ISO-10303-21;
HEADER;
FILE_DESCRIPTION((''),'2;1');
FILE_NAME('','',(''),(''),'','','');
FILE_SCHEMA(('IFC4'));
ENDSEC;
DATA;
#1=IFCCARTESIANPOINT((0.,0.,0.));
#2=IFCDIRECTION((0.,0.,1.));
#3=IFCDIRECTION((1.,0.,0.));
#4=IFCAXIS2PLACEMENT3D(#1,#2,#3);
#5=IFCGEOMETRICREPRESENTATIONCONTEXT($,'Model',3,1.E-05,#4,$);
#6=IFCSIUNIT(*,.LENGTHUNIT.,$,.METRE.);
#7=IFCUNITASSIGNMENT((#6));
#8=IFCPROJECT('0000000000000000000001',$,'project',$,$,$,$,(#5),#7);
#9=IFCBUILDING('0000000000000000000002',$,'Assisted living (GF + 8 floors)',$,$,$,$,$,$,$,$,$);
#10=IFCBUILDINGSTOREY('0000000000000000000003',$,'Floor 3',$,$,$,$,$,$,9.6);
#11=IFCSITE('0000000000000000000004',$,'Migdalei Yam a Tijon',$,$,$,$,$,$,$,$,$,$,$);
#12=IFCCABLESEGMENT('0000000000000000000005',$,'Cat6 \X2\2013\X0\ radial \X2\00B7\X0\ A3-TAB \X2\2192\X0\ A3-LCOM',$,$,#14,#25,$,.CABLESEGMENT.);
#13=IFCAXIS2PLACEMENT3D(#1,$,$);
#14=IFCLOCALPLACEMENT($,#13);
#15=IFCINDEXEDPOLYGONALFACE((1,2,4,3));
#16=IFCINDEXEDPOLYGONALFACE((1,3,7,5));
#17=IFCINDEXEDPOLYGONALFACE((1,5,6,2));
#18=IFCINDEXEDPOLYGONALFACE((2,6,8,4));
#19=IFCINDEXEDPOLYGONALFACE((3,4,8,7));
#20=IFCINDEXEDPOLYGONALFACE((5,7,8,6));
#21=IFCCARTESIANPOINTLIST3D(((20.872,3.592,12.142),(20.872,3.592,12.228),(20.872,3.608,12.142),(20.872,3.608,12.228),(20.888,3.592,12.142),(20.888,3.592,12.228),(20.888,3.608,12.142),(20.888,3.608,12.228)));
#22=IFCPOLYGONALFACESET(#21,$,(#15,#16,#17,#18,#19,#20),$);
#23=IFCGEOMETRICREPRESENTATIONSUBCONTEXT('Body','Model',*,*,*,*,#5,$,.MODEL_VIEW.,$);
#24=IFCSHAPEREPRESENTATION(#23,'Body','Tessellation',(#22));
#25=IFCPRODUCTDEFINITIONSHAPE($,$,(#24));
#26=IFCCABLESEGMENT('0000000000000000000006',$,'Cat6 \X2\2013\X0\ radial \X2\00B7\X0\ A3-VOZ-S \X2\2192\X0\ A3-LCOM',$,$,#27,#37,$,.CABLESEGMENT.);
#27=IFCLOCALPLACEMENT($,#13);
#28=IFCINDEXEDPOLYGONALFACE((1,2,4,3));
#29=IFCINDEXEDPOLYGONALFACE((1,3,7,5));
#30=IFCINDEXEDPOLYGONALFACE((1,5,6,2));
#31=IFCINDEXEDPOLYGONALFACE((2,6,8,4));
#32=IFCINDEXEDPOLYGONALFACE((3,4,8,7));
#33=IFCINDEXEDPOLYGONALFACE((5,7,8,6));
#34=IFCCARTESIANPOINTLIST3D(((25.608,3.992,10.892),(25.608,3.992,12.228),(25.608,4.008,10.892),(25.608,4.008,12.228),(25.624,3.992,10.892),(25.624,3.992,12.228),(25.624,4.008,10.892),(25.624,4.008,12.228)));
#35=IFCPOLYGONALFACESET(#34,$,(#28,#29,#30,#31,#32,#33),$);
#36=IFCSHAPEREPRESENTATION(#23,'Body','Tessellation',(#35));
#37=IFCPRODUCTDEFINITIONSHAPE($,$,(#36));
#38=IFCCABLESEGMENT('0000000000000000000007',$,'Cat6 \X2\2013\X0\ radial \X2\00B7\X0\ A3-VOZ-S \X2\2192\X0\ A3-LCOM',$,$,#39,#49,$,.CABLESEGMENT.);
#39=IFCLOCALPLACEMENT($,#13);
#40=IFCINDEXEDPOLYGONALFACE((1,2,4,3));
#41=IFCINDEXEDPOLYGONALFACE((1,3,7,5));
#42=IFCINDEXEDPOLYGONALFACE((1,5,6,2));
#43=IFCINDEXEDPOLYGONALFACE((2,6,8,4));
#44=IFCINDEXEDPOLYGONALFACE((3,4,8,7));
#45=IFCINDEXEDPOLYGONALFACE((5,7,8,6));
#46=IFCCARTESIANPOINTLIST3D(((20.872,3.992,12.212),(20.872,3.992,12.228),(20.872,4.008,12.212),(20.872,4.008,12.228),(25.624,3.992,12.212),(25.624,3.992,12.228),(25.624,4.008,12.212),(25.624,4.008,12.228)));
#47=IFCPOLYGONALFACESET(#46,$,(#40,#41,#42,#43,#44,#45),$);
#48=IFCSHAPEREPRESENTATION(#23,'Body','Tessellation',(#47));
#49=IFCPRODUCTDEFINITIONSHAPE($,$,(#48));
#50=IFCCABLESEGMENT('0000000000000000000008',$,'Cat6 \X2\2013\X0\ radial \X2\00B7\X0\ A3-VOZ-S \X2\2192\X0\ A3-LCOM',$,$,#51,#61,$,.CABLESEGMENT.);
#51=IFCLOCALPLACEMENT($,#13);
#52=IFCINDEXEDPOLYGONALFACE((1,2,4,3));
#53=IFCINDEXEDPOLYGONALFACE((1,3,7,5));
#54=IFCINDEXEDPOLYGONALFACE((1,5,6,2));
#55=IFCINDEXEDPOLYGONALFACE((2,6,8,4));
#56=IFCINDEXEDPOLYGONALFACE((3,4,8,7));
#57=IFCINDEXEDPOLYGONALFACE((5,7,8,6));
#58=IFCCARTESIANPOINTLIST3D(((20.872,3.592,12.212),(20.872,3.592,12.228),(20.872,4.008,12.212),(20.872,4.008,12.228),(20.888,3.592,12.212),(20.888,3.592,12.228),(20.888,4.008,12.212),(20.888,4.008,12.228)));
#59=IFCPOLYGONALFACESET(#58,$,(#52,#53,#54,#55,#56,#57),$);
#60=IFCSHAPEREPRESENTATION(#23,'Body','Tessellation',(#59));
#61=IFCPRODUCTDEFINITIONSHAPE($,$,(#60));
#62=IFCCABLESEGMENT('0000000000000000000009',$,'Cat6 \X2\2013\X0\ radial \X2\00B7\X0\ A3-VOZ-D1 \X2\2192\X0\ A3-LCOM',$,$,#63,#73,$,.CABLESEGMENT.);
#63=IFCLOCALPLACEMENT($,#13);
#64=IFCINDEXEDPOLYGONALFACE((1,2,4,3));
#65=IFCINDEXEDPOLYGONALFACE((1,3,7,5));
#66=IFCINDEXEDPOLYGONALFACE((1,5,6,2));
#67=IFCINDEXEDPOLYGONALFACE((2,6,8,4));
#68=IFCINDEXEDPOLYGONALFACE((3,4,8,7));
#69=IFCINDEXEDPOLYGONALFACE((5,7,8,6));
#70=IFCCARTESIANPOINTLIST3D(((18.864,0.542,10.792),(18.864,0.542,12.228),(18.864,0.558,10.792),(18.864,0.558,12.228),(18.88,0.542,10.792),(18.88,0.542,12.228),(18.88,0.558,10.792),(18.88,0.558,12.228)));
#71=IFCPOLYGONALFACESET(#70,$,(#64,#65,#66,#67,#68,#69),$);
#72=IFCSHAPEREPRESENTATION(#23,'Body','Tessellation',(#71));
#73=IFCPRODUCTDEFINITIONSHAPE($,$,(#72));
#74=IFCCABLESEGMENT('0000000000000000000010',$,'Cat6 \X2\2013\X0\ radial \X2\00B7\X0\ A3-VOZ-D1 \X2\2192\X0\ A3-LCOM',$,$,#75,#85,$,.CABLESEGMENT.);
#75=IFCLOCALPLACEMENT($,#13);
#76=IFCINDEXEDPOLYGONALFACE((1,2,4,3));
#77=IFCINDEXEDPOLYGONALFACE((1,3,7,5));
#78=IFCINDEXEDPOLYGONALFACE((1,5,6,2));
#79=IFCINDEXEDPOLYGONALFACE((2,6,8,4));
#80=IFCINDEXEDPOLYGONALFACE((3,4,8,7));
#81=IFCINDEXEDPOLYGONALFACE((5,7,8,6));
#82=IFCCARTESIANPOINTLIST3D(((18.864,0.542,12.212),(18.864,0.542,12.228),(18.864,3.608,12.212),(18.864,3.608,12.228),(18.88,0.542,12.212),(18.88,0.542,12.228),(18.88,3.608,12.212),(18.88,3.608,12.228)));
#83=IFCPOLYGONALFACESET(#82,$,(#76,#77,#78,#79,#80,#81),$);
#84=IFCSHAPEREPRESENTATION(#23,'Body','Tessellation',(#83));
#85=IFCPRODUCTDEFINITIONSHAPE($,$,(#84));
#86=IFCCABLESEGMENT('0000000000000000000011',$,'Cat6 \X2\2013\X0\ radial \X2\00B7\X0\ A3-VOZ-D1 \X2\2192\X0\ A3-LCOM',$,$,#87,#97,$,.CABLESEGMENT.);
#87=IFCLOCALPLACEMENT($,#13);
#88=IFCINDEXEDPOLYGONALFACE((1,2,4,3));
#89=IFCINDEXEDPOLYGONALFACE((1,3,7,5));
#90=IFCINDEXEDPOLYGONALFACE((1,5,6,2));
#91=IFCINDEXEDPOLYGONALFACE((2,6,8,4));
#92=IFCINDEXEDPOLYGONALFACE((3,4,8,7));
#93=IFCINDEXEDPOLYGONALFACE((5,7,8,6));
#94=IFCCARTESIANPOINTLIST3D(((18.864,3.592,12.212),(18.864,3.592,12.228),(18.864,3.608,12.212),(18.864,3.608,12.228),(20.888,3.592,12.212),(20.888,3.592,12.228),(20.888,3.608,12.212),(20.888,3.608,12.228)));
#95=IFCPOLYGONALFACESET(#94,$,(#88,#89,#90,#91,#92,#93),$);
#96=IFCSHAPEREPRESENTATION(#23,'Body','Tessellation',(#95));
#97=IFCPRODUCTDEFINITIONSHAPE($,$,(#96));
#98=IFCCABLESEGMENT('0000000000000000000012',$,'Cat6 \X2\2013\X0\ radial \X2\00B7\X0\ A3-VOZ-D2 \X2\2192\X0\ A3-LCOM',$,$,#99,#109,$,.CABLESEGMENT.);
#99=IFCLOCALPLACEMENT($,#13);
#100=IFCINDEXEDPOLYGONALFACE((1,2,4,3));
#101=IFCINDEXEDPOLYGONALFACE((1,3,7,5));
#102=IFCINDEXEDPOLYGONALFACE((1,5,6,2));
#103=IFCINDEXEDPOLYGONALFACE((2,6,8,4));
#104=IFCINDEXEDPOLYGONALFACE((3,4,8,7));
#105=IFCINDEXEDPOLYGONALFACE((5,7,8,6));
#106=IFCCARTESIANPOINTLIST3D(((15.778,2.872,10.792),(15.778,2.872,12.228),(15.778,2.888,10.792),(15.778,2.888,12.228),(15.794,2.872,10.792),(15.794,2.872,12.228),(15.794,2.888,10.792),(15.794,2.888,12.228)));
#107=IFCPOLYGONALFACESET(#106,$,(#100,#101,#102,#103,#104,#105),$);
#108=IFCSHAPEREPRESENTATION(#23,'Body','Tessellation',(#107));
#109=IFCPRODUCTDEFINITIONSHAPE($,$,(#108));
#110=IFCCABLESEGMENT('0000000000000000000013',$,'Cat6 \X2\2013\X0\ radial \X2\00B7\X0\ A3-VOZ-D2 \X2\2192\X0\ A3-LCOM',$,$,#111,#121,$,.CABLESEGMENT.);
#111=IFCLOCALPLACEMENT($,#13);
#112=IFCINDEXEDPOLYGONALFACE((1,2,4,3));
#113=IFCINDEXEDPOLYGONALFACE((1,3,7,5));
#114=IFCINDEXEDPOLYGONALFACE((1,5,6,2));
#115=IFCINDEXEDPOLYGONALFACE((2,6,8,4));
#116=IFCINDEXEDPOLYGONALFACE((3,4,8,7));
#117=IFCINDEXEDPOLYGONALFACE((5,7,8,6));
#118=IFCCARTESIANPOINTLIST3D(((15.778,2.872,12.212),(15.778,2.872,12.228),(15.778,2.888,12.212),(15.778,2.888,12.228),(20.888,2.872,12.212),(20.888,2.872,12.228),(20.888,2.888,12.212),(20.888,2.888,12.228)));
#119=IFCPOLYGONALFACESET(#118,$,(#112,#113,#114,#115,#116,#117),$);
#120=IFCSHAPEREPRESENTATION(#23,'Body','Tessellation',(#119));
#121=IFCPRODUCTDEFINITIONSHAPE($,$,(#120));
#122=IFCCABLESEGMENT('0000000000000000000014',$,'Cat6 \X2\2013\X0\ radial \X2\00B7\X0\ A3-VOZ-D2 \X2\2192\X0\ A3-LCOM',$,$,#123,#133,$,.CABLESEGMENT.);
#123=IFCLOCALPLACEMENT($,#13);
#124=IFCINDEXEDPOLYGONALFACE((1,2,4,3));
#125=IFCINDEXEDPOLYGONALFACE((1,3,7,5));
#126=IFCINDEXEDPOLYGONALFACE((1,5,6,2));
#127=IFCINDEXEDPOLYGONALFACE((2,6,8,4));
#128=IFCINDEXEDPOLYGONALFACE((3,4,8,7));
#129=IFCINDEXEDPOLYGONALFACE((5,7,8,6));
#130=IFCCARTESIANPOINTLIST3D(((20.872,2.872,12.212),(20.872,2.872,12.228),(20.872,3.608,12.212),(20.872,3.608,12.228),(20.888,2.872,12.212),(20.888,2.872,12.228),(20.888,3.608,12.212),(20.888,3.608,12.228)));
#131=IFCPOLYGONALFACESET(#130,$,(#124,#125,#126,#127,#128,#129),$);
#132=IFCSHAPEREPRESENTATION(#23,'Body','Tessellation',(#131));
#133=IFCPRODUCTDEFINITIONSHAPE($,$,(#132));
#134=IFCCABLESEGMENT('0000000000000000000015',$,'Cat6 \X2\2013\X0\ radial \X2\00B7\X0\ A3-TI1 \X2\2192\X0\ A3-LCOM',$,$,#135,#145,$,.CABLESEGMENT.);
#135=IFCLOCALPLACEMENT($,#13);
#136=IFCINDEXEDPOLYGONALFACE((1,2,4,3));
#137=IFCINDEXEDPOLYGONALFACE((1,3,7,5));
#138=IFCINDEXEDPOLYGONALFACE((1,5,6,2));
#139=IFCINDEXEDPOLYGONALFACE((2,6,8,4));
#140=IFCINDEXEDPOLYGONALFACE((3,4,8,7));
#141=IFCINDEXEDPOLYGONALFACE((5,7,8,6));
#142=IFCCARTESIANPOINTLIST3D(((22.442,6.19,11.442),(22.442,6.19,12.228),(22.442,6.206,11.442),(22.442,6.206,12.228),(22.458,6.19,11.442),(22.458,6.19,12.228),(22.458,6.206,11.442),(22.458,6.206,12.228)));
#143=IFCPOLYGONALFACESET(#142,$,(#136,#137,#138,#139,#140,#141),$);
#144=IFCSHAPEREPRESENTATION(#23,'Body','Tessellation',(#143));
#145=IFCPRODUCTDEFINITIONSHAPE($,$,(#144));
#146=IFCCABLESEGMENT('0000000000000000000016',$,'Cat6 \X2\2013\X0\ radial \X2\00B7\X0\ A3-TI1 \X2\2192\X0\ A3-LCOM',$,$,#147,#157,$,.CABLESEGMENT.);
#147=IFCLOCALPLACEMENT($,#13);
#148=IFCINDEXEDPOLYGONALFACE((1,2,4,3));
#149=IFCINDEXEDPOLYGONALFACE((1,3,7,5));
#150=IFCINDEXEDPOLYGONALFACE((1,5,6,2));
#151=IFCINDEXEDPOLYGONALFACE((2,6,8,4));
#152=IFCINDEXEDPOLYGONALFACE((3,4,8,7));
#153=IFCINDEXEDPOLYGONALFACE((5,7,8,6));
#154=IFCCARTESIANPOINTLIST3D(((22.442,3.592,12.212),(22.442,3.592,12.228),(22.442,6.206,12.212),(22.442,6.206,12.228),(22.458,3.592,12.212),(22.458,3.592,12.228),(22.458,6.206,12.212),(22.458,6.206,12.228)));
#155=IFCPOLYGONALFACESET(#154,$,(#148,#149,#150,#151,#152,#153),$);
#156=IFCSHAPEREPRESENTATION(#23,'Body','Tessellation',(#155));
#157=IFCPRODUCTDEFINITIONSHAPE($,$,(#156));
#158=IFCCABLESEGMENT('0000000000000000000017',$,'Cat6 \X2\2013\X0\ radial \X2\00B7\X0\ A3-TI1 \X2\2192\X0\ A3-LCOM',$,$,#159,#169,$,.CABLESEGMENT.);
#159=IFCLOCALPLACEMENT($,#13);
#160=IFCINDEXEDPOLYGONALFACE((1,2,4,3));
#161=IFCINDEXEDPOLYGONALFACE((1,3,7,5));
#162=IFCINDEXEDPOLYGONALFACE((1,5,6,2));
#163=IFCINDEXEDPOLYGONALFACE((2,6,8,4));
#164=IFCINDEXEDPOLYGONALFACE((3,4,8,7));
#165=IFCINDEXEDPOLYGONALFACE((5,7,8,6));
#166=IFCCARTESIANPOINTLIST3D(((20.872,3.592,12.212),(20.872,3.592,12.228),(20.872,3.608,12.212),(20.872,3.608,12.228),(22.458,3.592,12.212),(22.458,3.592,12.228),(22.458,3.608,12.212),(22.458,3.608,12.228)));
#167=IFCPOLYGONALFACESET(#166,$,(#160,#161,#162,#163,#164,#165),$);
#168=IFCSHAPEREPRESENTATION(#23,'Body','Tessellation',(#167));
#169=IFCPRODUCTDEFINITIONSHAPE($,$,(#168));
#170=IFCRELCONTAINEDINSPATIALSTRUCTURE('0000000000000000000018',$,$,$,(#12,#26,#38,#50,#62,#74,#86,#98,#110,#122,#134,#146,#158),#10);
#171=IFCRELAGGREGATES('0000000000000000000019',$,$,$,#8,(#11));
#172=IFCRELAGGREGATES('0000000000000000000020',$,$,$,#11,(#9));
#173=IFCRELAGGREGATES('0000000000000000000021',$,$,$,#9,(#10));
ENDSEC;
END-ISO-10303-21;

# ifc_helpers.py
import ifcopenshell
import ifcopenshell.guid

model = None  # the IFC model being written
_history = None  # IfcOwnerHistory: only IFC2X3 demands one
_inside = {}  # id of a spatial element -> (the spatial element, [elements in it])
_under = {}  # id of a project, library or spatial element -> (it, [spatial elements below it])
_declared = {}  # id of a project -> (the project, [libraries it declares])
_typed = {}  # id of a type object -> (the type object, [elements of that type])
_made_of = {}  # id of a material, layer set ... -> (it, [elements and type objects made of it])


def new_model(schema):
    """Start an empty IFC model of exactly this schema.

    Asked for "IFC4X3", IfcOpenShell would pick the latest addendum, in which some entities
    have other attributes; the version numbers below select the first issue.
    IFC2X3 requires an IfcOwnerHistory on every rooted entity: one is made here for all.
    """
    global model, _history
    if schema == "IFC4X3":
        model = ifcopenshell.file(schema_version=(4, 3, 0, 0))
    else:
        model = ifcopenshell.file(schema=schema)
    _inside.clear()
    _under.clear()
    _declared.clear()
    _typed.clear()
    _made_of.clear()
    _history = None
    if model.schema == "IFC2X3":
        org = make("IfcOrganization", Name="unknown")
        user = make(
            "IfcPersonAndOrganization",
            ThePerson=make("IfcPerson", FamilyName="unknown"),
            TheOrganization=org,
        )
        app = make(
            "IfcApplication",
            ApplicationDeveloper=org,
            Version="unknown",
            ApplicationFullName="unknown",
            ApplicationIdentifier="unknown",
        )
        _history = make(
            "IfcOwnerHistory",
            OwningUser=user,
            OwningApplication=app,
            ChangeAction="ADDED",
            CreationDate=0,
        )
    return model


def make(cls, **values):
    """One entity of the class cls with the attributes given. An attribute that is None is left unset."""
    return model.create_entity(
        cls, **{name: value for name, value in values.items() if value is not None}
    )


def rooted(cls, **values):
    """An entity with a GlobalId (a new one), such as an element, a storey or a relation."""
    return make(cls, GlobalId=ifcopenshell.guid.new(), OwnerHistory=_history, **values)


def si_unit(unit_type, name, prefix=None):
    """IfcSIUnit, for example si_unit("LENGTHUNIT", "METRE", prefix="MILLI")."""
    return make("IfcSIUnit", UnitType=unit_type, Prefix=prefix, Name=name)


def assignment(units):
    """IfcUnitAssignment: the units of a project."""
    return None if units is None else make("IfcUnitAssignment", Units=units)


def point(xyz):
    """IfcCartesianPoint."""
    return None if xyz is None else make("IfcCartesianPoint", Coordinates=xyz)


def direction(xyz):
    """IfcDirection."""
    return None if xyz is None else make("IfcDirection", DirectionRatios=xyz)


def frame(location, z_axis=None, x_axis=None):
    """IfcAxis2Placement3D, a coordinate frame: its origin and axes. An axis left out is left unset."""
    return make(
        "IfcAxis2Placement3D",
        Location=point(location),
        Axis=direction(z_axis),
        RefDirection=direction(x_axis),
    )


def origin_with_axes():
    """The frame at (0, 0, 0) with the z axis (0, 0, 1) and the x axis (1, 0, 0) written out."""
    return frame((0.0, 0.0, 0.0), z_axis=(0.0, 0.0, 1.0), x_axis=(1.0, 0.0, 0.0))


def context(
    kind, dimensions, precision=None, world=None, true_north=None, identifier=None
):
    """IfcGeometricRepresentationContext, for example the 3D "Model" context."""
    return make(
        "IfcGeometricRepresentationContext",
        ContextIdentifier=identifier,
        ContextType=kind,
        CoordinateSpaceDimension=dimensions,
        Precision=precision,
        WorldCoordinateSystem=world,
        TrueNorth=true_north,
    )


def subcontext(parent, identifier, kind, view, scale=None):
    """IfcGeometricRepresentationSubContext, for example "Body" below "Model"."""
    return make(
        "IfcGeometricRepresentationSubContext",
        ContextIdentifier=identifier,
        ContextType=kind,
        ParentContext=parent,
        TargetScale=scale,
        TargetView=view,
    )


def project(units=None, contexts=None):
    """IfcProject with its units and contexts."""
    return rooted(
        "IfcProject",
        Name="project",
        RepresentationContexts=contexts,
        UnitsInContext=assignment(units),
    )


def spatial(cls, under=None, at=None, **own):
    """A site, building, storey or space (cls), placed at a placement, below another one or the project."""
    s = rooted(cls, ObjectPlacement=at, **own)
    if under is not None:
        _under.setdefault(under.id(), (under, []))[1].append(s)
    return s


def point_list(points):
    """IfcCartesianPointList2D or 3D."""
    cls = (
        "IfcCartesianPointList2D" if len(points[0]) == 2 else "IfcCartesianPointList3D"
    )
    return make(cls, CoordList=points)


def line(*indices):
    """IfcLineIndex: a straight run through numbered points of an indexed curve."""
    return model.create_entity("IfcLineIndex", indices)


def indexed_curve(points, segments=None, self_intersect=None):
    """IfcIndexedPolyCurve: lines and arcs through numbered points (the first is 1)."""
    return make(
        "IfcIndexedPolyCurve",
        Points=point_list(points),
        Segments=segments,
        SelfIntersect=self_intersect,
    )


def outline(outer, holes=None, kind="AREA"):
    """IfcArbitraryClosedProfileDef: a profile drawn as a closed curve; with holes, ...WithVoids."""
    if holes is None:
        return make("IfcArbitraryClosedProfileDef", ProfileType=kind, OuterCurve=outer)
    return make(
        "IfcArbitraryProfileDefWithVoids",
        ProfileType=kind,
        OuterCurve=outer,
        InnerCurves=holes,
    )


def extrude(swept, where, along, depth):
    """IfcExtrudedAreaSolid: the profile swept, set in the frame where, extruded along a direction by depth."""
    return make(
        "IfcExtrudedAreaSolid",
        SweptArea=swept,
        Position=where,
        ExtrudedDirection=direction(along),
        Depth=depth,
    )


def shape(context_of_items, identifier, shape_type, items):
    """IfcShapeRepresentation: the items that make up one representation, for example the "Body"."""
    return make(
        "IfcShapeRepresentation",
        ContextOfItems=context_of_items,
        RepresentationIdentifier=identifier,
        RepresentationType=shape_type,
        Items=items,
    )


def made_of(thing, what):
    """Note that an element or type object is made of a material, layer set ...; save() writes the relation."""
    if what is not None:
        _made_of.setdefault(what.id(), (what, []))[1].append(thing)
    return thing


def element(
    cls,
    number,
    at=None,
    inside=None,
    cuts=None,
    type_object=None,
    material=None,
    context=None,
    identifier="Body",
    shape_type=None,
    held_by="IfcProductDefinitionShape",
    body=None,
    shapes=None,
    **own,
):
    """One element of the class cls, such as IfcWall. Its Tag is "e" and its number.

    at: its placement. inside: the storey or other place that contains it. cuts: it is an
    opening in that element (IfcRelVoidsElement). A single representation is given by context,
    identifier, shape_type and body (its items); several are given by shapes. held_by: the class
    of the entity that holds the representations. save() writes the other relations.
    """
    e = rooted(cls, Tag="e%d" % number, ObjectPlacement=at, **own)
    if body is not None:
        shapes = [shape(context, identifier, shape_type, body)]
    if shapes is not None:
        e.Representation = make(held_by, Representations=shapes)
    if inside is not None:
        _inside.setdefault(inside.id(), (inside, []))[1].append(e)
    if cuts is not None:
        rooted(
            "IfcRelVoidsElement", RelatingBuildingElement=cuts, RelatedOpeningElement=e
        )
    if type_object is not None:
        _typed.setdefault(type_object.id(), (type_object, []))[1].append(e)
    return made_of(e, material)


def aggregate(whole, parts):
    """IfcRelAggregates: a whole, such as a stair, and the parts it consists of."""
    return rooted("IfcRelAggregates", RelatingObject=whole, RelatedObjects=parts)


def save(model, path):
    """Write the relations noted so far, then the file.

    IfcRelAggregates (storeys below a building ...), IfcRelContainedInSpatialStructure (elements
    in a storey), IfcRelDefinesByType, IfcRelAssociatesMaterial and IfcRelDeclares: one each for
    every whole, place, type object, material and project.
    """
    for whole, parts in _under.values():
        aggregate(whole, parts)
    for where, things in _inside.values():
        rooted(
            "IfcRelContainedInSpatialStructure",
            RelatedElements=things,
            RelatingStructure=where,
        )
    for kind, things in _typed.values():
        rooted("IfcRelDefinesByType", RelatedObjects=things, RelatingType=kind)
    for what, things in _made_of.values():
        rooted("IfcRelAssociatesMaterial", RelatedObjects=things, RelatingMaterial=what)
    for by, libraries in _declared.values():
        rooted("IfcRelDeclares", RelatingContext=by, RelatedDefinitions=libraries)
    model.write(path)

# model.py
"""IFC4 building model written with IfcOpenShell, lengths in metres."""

from ifc_helpers import new_model, si_unit, frame, origin_with_axes, context, subcontext, project, spatial, line, indexed_curve, outline, extrude, element, save


model = new_model("IFC4")

# Units and contexts
model_context = context("Model", 3, precision=1e-05, world=origin_with_axes())
body_context = subcontext(model_context, "Body", "Model", "MODEL_VIEW")
ifc_project = project(units=[si_unit("LENGTHUNIT", "METRE")], contexts=[model_context])

# Site, building, storey
site = spatial("IfcSite", under=ifc_project, Name="Migdalei Yam a Tijon")
building = spatial("IfcBuilding", under=site, Name="Assisted living (GF + 8 floors)")
storey = spatial("IfcBuildingStorey", under=building, Name="Floor 3", Elevation=9.6)

# Cable segments
element("IfcCableSegment", 1, inside=storey, Name="Cat6 – radial · A3-TAB → A3-LCOM", PredefinedType="CABLESEGMENT", context=body_context, shape_type="SweptSolid", body=[
    extrude(outline(indexed_curve([(0.0, 0.0), (0.016, 0.0), (0.016, 0.016), (0.0, 0.016)], segments=[line(1, 2, 3, 4, 1)])), frame((20.872, 3.592, 12.142), z_axis=(0.0, 0.0, 1.0), x_axis=(1.0, 0.0, 0.0)), (0.0, 0.0, 1.0), 0.086),
])
element("IfcCableSegment", 2, inside=storey, Name="Cat6 – radial · A3-VOZ-S → A3-LCOM", PredefinedType="CABLESEGMENT", context=body_context, shape_type="SweptSolid", body=[
    extrude(outline(indexed_curve([(0.0, 0.0), (0.016, 0.0), (0.016, 0.016), (0.0, 0.016)], segments=[line(1, 2, 3, 4, 1)])), frame((25.608, 3.992, 10.892), z_axis=(0.0, 0.0, 1.0), x_axis=(1.0, 0.0, 0.0)), (0.0, 0.0, 1.0), 1.336),
])
element("IfcCableSegment", 3, inside=storey, Name="Cat6 – radial · A3-VOZ-S → A3-LCOM", PredefinedType="CABLESEGMENT", context=body_context, shape_type="SweptSolid", body=[
    extrude(outline(indexed_curve([(0.0, 0.0), (4.752, 0.0), (4.752, 0.016), (0.0, 0.016)], segments=[line(1, 2, 3, 4, 1)])), frame((20.872, 3.992, 12.212), z_axis=(0.0, 0.0, 1.0), x_axis=(1.0, 0.0, 0.0)), (0.0, 0.0, 1.0), 0.016),
])
element("IfcCableSegment", 4, inside=storey, Name="Cat6 – radial · A3-VOZ-S → A3-LCOM", PredefinedType="CABLESEGMENT", context=body_context, shape_type="SweptSolid", body=[
    extrude(outline(indexed_curve([(0.0, 0.0), (0.016, 0.0), (0.016, 0.416), (0.0, 0.416)], segments=[line(1, 2, 3, 4, 1)])), frame((20.872, 3.592, 12.212), z_axis=(0.0, 0.0, 1.0), x_axis=(1.0, 0.0, 0.0)), (0.0, 0.0, 1.0), 0.016),
])
element("IfcCableSegment", 5, inside=storey, Name="Cat6 – radial · A3-VOZ-D1 → A3-LCOM", PredefinedType="CABLESEGMENT", context=body_context, shape_type="SweptSolid", body=[
    extrude(outline(indexed_curve([(0.0, 0.0), (0.016, 0.0), (0.016, 0.016), (0.0, 0.016)], segments=[line(1, 2, 3, 4, 1)])), frame((18.864, 0.542, 10.792), z_axis=(0.0, 0.0, 1.0), x_axis=(1.0, 0.0, 0.0)), (0.0, 0.0, 1.0), 1.436),
])
element("IfcCableSegment", 6, inside=storey, Name="Cat6 – radial · A3-VOZ-D1 → A3-LCOM", PredefinedType="CABLESEGMENT", context=body_context, shape_type="SweptSolid", body=[
    extrude(outline(indexed_curve([(0.0, 0.0), (0.016, 0.0), (0.016, 3.066), (0.0, 3.066)], segments=[line(1, 2, 3, 4, 1)])), frame((18.864, 0.542, 12.212), z_axis=(0.0, 0.0, 1.0), x_axis=(1.0, 0.0, 0.0)), (0.0, 0.0, 1.0), 0.016),
])
element("IfcCableSegment", 7, inside=storey, Name="Cat6 – radial · A3-VOZ-D1 → A3-LCOM", PredefinedType="CABLESEGMENT", context=body_context, shape_type="SweptSolid", body=[
    extrude(outline(indexed_curve([(0.0, 0.0), (2.024, 0.0), (2.024, 0.016), (0.0, 0.016)], segments=[line(1, 2, 3, 4, 1)])), frame((18.864, 3.592, 12.212), z_axis=(0.0, 0.0, 1.0), x_axis=(1.0, 0.0, 0.0)), (0.0, 0.0, 1.0), 0.016),
])
element("IfcCableSegment", 8, inside=storey, Name="Cat6 – radial · A3-VOZ-D2 → A3-LCOM", PredefinedType="CABLESEGMENT", context=body_context, shape_type="SweptSolid", body=[
    extrude(outline(indexed_curve([(0.0, 0.0), (0.016, 0.0), (0.016, 0.016), (0.0, 0.016)], segments=[line(1, 2, 3, 4, 1)])), frame((15.778, 2.872, 10.792), z_axis=(0.0, 0.0, 1.0), x_axis=(1.0, 0.0, 0.0)), (0.0, 0.0, 1.0), 1.436),
])
element("IfcCableSegment", 9, inside=storey, Name="Cat6 – radial · A3-VOZ-D2 → A3-LCOM", PredefinedType="CABLESEGMENT", context=body_context, shape_type="SweptSolid", body=[
    extrude(outline(indexed_curve([(0.0, 0.0), (5.11, 0.0), (5.11, 0.016), (0.0, 0.016)], segments=[line(1, 2, 3, 4, 1)])), frame((15.778, 2.872, 12.212), z_axis=(0.0, 0.0, 1.0), x_axis=(1.0, 0.0, 0.0)), (0.0, 0.0, 1.0), 0.016),
])
element("IfcCableSegment", 10, inside=storey, Name="Cat6 – radial · A3-VOZ-D2 → A3-LCOM", PredefinedType="CABLESEGMENT", context=body_context, shape_type="SweptSolid", body=[
    extrude(outline(indexed_curve([(0.0, 0.0), (0.016, 0.0), (0.016, 0.736), (0.0, 0.736)], segments=[line(1, 2, 3, 4, 1)])), frame((20.872, 2.872, 12.212), z_axis=(0.0, 0.0, 1.0), x_axis=(1.0, 0.0, 0.0)), (0.0, 0.0, 1.0), 0.016),
])
element("IfcCableSegment", 11, inside=storey, Name="Cat6 – radial · A3-TI1 → A3-LCOM", PredefinedType="CABLESEGMENT", context=body_context, shape_type="SweptSolid", body=[
    extrude(outline(indexed_curve([(0.0, 0.0), (0.016, 0.0), (0.016, 0.016), (0.0, 0.016)], segments=[line(1, 2, 3, 4, 1)])), frame((22.442, 6.19, 11.442), z_axis=(0.0, 0.0, 1.0), x_axis=(1.0, 0.0, 0.0)), (0.0, 0.0, 1.0), 0.786),
])
element("IfcCableSegment", 12, inside=storey, Name="Cat6 – radial · A3-TI1 → A3-LCOM", PredefinedType="CABLESEGMENT", context=body_context, shape_type="SweptSolid", body=[
    extrude(outline(indexed_curve([(0.0, 0.0), (0.016, 0.0), (0.016, 2.614), (0.0, 2.614)], segments=[line(1, 2, 3, 4, 1)])), frame((22.442, 3.592, 12.212), z_axis=(0.0, 0.0, 1.0), x_axis=(1.0, 0.0, 0.0)), (0.0, 0.0, 1.0), 0.016),
])
element("IfcCableSegment", 13, inside=storey, Name="Cat6 – radial · A3-TI1 → A3-LCOM", PredefinedType="CABLESEGMENT", context=body_context, shape_type="SweptSolid", body=[
    extrude(outline(indexed_curve([(0.0, 0.0), (1.586, 0.0), (1.586, 0.016), (0.0, 0.016)], segments=[line(1, 2, 3, 4, 1)])), frame((20.872, 3.592, 12.212), z_axis=(0.0, 0.0, 1.0), x_axis=(1.0, 0.0, 0.0)), (0.0, 0.0, 1.0), 0.016),
])

save(model, "model.ifc")
